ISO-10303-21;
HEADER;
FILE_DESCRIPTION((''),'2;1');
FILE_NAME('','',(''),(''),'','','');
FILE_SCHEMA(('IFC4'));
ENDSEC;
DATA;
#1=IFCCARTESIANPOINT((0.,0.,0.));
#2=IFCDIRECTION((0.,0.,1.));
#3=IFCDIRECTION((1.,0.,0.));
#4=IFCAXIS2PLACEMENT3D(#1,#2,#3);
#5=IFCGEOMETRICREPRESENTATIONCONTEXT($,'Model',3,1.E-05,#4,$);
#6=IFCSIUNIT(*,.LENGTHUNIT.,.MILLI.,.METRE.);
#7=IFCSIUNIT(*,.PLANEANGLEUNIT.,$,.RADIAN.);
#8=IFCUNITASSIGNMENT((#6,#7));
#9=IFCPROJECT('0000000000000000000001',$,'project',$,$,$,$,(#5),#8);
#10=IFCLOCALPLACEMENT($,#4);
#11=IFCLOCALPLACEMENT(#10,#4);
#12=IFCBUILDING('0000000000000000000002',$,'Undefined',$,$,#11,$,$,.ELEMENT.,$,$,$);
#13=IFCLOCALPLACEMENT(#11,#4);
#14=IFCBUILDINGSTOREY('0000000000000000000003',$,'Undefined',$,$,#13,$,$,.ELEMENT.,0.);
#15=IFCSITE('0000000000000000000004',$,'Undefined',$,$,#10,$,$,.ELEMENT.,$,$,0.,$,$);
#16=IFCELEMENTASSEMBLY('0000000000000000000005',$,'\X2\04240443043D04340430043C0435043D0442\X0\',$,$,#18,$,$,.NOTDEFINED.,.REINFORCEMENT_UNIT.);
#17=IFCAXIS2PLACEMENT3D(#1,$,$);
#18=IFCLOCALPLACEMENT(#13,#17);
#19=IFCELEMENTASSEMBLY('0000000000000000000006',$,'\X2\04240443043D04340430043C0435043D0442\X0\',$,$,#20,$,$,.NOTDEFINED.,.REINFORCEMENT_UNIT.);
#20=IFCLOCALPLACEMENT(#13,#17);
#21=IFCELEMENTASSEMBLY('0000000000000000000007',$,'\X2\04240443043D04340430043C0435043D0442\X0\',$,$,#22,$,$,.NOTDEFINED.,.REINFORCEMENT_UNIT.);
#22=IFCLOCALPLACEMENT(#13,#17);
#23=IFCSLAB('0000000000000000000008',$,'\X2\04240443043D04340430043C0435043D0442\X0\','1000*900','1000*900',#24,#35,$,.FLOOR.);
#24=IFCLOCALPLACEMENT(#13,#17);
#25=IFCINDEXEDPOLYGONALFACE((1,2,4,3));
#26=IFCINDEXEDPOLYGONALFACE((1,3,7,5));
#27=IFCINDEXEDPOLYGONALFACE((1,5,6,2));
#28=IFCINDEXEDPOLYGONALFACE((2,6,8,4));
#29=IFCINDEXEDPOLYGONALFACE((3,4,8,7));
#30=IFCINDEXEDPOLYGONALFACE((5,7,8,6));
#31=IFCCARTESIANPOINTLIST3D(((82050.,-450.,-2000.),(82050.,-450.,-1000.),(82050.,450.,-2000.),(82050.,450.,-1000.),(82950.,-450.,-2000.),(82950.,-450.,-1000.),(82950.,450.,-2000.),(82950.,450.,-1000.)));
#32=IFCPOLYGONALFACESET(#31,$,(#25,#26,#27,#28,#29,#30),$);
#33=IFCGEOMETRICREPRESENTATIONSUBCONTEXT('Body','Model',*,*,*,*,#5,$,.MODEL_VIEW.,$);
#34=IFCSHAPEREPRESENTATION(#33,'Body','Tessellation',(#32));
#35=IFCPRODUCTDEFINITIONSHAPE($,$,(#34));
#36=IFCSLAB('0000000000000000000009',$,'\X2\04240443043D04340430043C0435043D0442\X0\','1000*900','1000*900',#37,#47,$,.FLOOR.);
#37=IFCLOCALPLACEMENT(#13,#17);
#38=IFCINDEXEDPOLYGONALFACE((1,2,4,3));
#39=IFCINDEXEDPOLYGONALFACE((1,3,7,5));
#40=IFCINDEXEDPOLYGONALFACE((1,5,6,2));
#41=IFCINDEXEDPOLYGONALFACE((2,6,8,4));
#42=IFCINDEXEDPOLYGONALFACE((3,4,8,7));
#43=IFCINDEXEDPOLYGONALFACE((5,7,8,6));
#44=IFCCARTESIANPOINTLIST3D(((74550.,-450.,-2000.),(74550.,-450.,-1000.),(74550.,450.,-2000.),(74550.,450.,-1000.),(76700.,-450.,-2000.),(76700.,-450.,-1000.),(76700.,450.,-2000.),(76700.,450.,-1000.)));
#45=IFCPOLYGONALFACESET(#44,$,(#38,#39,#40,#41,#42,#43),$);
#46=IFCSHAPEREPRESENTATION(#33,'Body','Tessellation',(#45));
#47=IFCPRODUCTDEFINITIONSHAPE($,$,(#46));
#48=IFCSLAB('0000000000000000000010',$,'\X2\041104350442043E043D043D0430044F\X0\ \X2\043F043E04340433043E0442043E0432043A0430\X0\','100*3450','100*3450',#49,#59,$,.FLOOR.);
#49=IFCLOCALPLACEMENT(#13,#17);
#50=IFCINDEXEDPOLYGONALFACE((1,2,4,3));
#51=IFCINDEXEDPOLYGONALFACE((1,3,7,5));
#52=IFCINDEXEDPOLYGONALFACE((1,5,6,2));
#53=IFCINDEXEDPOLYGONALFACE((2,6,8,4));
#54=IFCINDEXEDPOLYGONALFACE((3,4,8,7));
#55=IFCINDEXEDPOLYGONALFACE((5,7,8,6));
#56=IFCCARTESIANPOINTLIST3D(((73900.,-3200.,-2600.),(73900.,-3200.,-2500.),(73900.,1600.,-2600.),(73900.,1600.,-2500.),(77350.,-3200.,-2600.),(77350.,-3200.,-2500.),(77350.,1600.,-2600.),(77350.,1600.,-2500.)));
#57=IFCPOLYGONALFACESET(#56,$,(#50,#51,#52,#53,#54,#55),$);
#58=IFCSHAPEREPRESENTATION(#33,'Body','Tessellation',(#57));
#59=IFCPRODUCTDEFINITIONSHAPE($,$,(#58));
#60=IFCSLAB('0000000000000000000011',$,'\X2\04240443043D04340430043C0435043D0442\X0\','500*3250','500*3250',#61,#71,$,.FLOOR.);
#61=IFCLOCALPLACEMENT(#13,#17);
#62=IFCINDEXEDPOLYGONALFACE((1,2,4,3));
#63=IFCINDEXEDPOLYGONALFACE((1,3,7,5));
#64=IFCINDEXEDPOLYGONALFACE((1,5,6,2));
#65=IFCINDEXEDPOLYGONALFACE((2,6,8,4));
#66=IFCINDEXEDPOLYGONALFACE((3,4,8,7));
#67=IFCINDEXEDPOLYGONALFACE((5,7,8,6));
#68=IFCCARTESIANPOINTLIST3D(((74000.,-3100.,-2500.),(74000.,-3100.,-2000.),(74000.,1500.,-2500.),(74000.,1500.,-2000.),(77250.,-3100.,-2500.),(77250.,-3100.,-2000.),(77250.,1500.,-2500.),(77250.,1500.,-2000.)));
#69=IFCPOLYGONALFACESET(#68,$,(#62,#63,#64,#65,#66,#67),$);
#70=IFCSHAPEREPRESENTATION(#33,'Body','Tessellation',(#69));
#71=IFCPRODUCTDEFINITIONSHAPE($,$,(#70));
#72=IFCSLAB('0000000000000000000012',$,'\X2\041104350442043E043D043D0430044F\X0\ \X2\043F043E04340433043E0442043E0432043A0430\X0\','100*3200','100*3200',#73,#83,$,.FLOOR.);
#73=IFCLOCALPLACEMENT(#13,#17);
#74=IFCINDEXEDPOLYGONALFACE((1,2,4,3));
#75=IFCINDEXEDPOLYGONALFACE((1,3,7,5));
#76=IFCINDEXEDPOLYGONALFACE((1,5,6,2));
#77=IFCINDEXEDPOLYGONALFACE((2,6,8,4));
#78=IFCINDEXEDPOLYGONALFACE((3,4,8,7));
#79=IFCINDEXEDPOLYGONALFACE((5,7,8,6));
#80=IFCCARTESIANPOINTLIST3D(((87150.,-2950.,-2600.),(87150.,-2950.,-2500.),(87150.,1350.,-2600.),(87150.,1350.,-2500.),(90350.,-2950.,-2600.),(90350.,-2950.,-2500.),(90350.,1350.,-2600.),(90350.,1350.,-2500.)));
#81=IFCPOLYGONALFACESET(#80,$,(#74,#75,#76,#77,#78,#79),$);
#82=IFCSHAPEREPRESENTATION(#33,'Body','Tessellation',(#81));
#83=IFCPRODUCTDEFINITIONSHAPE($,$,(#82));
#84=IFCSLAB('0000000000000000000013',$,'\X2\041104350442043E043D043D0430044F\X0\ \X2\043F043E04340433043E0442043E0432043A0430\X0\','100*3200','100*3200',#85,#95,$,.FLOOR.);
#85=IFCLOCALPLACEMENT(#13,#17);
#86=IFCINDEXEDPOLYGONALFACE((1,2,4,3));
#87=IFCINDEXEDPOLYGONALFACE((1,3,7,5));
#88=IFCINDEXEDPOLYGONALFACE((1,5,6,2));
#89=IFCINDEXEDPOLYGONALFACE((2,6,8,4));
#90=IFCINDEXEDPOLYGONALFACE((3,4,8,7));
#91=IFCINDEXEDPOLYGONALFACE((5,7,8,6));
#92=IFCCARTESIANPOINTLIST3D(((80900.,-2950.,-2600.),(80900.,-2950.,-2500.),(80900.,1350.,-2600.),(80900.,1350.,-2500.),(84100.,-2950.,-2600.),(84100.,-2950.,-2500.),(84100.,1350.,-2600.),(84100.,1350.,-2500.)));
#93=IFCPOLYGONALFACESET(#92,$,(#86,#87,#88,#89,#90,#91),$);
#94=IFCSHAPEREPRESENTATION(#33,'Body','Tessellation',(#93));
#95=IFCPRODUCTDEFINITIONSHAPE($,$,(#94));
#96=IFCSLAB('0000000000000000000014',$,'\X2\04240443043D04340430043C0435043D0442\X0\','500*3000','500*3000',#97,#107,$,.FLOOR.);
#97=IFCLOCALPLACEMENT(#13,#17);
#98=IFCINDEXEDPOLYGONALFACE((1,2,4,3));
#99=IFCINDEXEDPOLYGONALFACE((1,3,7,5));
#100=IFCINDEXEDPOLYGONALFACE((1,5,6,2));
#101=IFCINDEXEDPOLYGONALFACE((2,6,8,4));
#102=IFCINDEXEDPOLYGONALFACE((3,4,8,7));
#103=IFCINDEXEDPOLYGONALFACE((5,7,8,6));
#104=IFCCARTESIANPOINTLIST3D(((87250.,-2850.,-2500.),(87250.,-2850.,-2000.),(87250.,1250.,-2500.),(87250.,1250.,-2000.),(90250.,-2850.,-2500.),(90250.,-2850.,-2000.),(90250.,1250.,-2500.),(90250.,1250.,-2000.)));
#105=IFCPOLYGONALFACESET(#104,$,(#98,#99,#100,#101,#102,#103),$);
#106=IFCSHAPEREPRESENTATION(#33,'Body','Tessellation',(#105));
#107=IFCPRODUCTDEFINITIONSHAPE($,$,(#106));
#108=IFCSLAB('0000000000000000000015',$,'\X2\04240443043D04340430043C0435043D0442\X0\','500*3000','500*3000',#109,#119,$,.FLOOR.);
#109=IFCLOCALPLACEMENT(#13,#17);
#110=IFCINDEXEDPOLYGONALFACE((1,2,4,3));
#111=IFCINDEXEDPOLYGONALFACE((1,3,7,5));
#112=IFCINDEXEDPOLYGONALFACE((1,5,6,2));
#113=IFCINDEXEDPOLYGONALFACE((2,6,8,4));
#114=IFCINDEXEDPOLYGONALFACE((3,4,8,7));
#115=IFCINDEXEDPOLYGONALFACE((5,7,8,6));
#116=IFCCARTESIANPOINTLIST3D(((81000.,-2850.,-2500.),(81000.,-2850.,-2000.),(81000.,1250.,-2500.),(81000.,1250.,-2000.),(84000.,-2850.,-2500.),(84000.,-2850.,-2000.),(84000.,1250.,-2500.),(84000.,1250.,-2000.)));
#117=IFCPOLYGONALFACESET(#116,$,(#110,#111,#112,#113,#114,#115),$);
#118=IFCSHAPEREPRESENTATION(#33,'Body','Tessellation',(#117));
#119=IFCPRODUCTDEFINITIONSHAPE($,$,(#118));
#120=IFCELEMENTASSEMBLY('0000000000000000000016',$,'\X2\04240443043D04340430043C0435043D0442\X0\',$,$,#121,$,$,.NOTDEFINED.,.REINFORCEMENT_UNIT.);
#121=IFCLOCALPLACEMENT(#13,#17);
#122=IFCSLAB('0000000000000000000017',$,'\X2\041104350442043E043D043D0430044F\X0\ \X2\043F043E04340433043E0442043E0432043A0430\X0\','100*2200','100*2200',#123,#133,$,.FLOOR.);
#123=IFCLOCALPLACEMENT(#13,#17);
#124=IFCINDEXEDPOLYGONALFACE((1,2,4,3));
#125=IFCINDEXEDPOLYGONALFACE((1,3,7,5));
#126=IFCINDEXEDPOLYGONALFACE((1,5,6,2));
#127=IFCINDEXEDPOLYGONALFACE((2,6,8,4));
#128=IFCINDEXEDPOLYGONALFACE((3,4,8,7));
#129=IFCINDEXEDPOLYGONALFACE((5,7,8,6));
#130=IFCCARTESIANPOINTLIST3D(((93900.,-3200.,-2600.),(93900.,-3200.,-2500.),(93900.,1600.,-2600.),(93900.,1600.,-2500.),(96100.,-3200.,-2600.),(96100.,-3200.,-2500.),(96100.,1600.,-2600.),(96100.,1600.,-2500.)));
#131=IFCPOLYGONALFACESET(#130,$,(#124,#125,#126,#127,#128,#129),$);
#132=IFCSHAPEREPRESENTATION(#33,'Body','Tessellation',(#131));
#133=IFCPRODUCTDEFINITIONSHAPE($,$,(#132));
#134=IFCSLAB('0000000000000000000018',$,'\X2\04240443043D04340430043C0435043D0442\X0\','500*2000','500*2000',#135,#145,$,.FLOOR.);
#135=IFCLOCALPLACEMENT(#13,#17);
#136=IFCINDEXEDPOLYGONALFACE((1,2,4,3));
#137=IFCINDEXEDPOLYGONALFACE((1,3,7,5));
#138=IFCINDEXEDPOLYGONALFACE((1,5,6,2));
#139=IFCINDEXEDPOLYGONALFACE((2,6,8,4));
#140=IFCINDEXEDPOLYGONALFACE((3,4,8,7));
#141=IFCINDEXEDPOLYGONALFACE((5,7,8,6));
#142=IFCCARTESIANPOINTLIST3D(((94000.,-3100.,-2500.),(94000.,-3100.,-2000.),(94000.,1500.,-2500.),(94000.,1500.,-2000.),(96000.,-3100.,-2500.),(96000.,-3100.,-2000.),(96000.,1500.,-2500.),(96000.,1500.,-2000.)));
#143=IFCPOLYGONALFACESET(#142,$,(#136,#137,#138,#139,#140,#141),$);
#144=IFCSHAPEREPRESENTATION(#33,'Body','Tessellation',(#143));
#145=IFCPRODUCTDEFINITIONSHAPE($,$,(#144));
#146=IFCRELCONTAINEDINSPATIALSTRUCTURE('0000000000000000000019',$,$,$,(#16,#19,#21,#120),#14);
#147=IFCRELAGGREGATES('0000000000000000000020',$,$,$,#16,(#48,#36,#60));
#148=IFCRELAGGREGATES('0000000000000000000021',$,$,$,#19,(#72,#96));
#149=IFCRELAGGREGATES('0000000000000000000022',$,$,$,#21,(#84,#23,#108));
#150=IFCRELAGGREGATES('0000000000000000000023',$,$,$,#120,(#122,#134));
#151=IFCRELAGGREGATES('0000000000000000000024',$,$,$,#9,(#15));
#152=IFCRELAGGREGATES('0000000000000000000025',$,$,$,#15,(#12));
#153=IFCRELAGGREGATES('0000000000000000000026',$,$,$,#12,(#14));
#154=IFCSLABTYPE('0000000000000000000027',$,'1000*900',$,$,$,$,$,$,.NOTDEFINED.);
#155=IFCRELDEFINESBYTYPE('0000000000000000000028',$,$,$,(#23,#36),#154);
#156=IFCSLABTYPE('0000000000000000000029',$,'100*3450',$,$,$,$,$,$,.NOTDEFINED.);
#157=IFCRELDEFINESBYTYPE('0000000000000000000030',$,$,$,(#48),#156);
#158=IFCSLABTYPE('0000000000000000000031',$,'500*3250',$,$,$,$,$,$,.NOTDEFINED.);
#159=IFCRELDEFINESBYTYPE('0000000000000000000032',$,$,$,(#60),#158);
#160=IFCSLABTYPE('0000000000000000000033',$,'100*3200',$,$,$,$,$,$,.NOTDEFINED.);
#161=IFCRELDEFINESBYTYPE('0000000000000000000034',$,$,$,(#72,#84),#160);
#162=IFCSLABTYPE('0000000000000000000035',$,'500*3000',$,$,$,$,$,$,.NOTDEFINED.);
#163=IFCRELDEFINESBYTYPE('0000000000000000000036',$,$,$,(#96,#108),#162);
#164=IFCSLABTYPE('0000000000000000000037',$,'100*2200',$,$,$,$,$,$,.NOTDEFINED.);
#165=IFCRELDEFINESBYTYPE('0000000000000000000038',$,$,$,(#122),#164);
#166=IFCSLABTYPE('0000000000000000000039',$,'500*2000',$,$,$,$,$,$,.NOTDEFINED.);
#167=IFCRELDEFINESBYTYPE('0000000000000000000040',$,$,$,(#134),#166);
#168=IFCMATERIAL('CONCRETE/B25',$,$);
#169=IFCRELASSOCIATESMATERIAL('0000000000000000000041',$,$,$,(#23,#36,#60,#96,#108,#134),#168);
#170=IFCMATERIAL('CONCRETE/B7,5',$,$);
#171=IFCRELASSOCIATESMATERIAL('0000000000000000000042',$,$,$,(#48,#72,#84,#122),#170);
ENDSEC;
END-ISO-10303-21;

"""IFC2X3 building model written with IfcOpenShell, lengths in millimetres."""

from ifc_helpers import new_model, si_unit, frame, origin_with_axes, place, context, subcontext, project, spatial, polyline, outline, extrude, material, type_object, element, aggregate, save


model = new_model("IFC2X3")

# Units and contexts
model_context = context("Model", 3, precision=1e-05, world=origin_with_axes())
body_context = subcontext(model_context, "Body", "Model", "MODEL_VIEW")
ifc_project = project(units=[si_unit("LENGTHUNIT", "METRE", prefix="MILLI"), si_unit("PLANEANGLEUNIT", "RADIAN")], contexts=[model_context])

# Site, building, storey
site_placement = place(None, origin_with_axes())
site = spatial("IfcSite", under=ifc_project, at=site_placement, Name="Undefined", CompositionType="ELEMENT", RefElevation=0.0)
building_placement = place(site_placement, origin_with_axes())
building = spatial("IfcBuilding", under=site, at=building_placement, Name="Undefined", CompositionType="ELEMENT")
storey_placement = place(building_placement, origin_with_axes())
storey = spatial("IfcBuildingStorey", under=building, at=storey_placement, Name="Undefined", CompositionType="ELEMENT", Elevation=0.0)

# Element assembly
assembly_1_placement = place(storey_placement, origin_with_axes())
assembly_1 = element("IfcElementAssembly", 1, at=assembly_1_placement, inside=storey, Name="Фундамент", AssemblyPlace="NOTDEFINED", PredefinedType="REINFORCEMENT_UNIT")
ifc_material_1 = material(Name="CONCRETE/B25")

# Element assemblies
assembly_2_placement = place(storey_placement, origin_with_axes())
assembly_2 = element("IfcElementAssembly", 2, at=assembly_2_placement, inside=storey, Name="Фундамент", AssemblyPlace="NOTDEFINED", PredefinedType="REINFORCEMENT_UNIT")
assembly_3_placement = place(storey_placement, origin_with_axes())
assembly_3 = element("IfcElementAssembly", 3, at=assembly_3_placement, inside=storey, Name="Фундамент", AssemblyPlace="NOTDEFINED", PredefinedType="REINFORCEMENT_UNIT")

# Slabs
slab_type_1 = type_object("IfcSlabType", Name="1000*900", PredefinedType="NOTDEFINED")
slab_1_placement = place(assembly_3_placement, frame((82050.0, 450.0, -1500.0), z_axis=(0.0, 0.0, 1.0), x_axis=(0.0, -1.0, 0.0)))
slab_1 = element("IfcSlab", 4, at=slab_1_placement, type_object=slab_type_1, material=ifc_material_1, Name="Фундамент", Description="1000*900", ObjectType="1000*900", PredefinedType="FLOOR", context=body_context, shape_type="SweptSolid", body=[
    extrude(outline(polyline([(0.0, 0.0), (900.0, 0.0), (900.0, 900.0), (0.0, 900.0), (0.0, 0.0)])), frame((0.0, 0.0, -500.0), z_axis=(0.0, 0.0, 1.0), x_axis=(1.0, 0.0, 0.0)), (0.0, 0.0, 1.0), 1000.0),
])
slab_2_placement = place(assembly_1_placement, frame((74550.0, 450.0, -1500.0), z_axis=(0.0, 0.0, 1.0), x_axis=(0.0, -1.0, 0.0)))
slab_2 = element("IfcSlab", 5, at=slab_2_placement, type_object=slab_type_1, material=ifc_material_1, Name="Фундамент", Description="1000*900", ObjectType="1000*900", PredefinedType="FLOOR", context=body_context, shape_type="SweptSolid", body=[
    extrude(outline(polyline([(0.0, 0.0), (900.0, 0.0), (900.0, 2150.0), (0.0, 2150.0), (0.0, 0.0)])), frame((0.0, 0.0, -500.0), z_axis=(0.0, 0.0, 1.0), x_axis=(1.0, 0.0, 0.0)), (0.0, 0.0, 1.0), 1000.0),
])
ifc_material_2 = material(Name="CONCRETE/B7,5")
slab_type_2 = type_object("IfcSlabType", Name="100*3450", PredefinedType="NOTDEFINED")
slab_3_placement = place(assembly_1_placement, frame((73900.0, 1600.0, -2550.0), z_axis=(0.0, 0.0, 1.0), x_axis=(0.0, -1.0, 0.0)))
slab_3 = element("IfcSlab", 6, at=slab_3_placement, type_object=slab_type_2, material=ifc_material_2, Name="Бетонная подготовка", Description="100*3450", ObjectType="100*3450", PredefinedType="FLOOR", context=body_context, shape_type="SweptSolid", body=[
    extrude(outline(polyline([(0.0, 0.0), (4800.0, 0.0), (4800.0, 3450.0), (0.0, 3450.0), (0.0, 0.0)])), frame((0.0, 0.0, -50.0), z_axis=(0.0, 0.0, 1.0), x_axis=(1.0, 0.0, 0.0)), (0.0, 0.0, 1.0), 100.0),
])
slab_type_3 = type_object("IfcSlabType", Name="500*3250", PredefinedType="NOTDEFINED")
slab_4_placement = place(assembly_1_placement, frame((74000.0, 1500.0, -2250.0), z_axis=(0.0, 0.0, 1.0), x_axis=(0.0, -1.0, 0.0)))
slab_4 = element("IfcSlab", 7, at=slab_4_placement, type_object=slab_type_3, material=ifc_material_1, Name="Фундамент", Description="500*3250", ObjectType="500*3250", PredefinedType="FLOOR", context=body_context, shape_type="SweptSolid", body=[
    extrude(outline(polyline([(0.0, 0.0), (4600.0, 0.0), (4600.0, 3250.0), (0.0, 3250.0), (0.0, 0.0)])), frame((0.0, 0.0, -250.0), z_axis=(0.0, 0.0, 1.0), x_axis=(1.0, 0.0, 0.0)), (0.0, 0.0, 1.0), 500.0),
])
aggregate(assembly_1, [slab_3, slab_2, slab_4])
slab_type_4 = type_object("IfcSlabType", Name="100*3200", PredefinedType="NOTDEFINED")
slab_5_placement = place(assembly_2_placement, frame((87150.0, 1350.0, -2550.0), z_axis=(0.0, 0.0, 1.0), x_axis=(0.0, -1.0, 0.0)))
slab_5 = element("IfcSlab", 8, at=slab_5_placement, type_object=slab_type_4, material=ifc_material_2, Name="Бетонная подготовка", Description="100*3200", ObjectType="100*3200", PredefinedType="FLOOR", context=body_context, shape_type="SweptSolid", body=[
    extrude(outline(polyline([(0.0, 0.0), (4300.0, 0.0), (4300.0, 3200.0), (0.0, 3200.0), (0.0, 0.0)])), frame((0.0, 0.0, -50.0), z_axis=(0.0, 0.0, 1.0), x_axis=(1.0, 0.0, 0.0)), (0.0, 0.0, 1.0), 100.0),
])
slab_6_placement = place(assembly_3_placement, frame((80900.0, 1350.0, -2550.0), z_axis=(0.0, 0.0, 1.0), x_axis=(0.0, -1.0, 0.0)))
slab_6 = element("IfcSlab", 9, at=slab_6_placement, type_object=slab_type_4, material=ifc_material_2, Name="Бетонная подготовка", Description="100*3200", ObjectType="100*3200", PredefinedType="FLOOR", context=body_context, shape_type="SweptSolid", body=[
    extrude(outline(polyline([(0.0, 0.0), (4300.0, 0.0), (4300.0, 3200.0), (0.0, 3200.0), (0.0, 0.0)])), frame((0.0, 0.0, -50.0), z_axis=(0.0, 0.0, 1.0), x_axis=(1.0, 0.0, 0.0)), (0.0, 0.0, 1.0), 100.0),
])
slab_type_5 = type_object("IfcSlabType", Name="500*3000", PredefinedType="NOTDEFINED")
slab_7_placement = place(assembly_2_placement, frame((87250.0, 1250.0, -2250.0), z_axis=(0.0, 0.0, 1.0), x_axis=(0.0, -1.0, 0.0)))
slab_7 = element("IfcSlab", 10, at=slab_7_placement, type_object=slab_type_5, material=ifc_material_1, Name="Фундамент", Description="500*3000", ObjectType="500*3000", PredefinedType="FLOOR", context=body_context, shape_type="SweptSolid", body=[
    extrude(outline(polyline([(0.0, 0.0), (4100.0, 0.0), (4100.0, 3000.0), (0.0, 3000.0), (0.0, 0.0)])), frame((0.0, 0.0, -250.0), z_axis=(0.0, 0.0, 1.0), x_axis=(1.0, 0.0, 0.0)), (0.0, 0.0, 1.0), 500.0),
])
aggregate(assembly_2, [slab_5, slab_7])
slab_8_placement = place(assembly_3_placement, frame((81000.0, 1250.0, -2250.0), z_axis=(0.0, 0.0, 1.0), x_axis=(0.0, -1.0, 0.0)))
slab_8 = element("IfcSlab", 11, at=slab_8_placement, type_object=slab_type_5, material=ifc_material_1, Name="Фундамент", Description="500*3000", ObjectType="500*3000", PredefinedType="FLOOR", context=body_context, shape_type="SweptSolid", body=[
    extrude(outline(polyline([(0.0, 0.0), (4100.0, 0.0), (4100.0, 3000.0), (0.0, 3000.0), (0.0, 0.0)])), frame((0.0, 0.0, -250.0), z_axis=(0.0, 0.0, 1.0), x_axis=(1.0, 0.0, 0.0)), (0.0, 0.0, 1.0), 500.0),
])
aggregate(assembly_3, [slab_6, slab_1, slab_8])

# Element assembly, slabs
assembly_4_placement = place(storey_placement, origin_with_axes())
assembly_4 = element("IfcElementAssembly", 12, at=assembly_4_placement, inside=storey, Name="Фундамент", AssemblyPlace="NOTDEFINED", PredefinedType="REINFORCEMENT_UNIT")
slab_type_6 = type_object("IfcSlabType", Name="100*2200", PredefinedType="NOTDEFINED")
slab_9_placement = place(assembly_4_placement, frame((93900.0, 1600.0, -2550.0), z_axis=(0.0, 0.0, 1.0), x_axis=(0.0, -1.0, 0.0)))
slab_9 = element("IfcSlab", 13, at=slab_9_placement, type_object=slab_type_6, material=ifc_material_2, Name="Бетонная подготовка", Description="100*2200", ObjectType="100*2200", PredefinedType="FLOOR", context=body_context, shape_type="SweptSolid", body=[
    extrude(outline(polyline([(0.0, 0.0), (4800.0, 0.0), (4800.0, 2200.0), (0.0, 2200.0), (0.0, 0.0)])), frame((0.0, 0.0, -50.0), z_axis=(0.0, 0.0, 1.0), x_axis=(1.0, 0.0, 0.0)), (0.0, 0.0, 1.0), 100.0),
])
slab_type_7 = type_object("IfcSlabType", Name="500*2000", PredefinedType="NOTDEFINED")
slab_10_placement = place(assembly_4_placement, frame((94000.0, 1500.0, -2250.0), z_axis=(0.0, 0.0, 1.0), x_axis=(0.0, -1.0, 0.0)))
slab_10 = element("IfcSlab", 14, at=slab_10_placement, type_object=slab_type_7, material=ifc_material_1, Name="Фундамент", Description="500*2000", ObjectType="500*2000", PredefinedType="FLOOR", context=body_context, shape_type="SweptSolid", body=[
    extrude(outline(polyline([(0.0, 0.0), (4600.0, 0.0), (4600.0, 2000.0), (0.0, 2000.0), (0.0, 0.0)])), frame((0.0, 0.0, -250.0), z_axis=(0.0, 0.0, 1.0), x_axis=(1.0, 0.0, 0.0)), (0.0, 0.0, 1.0), 500.0),
])
aggregate(assembly_4, [slab_9, slab_10])

save(model, "model.ifc")
